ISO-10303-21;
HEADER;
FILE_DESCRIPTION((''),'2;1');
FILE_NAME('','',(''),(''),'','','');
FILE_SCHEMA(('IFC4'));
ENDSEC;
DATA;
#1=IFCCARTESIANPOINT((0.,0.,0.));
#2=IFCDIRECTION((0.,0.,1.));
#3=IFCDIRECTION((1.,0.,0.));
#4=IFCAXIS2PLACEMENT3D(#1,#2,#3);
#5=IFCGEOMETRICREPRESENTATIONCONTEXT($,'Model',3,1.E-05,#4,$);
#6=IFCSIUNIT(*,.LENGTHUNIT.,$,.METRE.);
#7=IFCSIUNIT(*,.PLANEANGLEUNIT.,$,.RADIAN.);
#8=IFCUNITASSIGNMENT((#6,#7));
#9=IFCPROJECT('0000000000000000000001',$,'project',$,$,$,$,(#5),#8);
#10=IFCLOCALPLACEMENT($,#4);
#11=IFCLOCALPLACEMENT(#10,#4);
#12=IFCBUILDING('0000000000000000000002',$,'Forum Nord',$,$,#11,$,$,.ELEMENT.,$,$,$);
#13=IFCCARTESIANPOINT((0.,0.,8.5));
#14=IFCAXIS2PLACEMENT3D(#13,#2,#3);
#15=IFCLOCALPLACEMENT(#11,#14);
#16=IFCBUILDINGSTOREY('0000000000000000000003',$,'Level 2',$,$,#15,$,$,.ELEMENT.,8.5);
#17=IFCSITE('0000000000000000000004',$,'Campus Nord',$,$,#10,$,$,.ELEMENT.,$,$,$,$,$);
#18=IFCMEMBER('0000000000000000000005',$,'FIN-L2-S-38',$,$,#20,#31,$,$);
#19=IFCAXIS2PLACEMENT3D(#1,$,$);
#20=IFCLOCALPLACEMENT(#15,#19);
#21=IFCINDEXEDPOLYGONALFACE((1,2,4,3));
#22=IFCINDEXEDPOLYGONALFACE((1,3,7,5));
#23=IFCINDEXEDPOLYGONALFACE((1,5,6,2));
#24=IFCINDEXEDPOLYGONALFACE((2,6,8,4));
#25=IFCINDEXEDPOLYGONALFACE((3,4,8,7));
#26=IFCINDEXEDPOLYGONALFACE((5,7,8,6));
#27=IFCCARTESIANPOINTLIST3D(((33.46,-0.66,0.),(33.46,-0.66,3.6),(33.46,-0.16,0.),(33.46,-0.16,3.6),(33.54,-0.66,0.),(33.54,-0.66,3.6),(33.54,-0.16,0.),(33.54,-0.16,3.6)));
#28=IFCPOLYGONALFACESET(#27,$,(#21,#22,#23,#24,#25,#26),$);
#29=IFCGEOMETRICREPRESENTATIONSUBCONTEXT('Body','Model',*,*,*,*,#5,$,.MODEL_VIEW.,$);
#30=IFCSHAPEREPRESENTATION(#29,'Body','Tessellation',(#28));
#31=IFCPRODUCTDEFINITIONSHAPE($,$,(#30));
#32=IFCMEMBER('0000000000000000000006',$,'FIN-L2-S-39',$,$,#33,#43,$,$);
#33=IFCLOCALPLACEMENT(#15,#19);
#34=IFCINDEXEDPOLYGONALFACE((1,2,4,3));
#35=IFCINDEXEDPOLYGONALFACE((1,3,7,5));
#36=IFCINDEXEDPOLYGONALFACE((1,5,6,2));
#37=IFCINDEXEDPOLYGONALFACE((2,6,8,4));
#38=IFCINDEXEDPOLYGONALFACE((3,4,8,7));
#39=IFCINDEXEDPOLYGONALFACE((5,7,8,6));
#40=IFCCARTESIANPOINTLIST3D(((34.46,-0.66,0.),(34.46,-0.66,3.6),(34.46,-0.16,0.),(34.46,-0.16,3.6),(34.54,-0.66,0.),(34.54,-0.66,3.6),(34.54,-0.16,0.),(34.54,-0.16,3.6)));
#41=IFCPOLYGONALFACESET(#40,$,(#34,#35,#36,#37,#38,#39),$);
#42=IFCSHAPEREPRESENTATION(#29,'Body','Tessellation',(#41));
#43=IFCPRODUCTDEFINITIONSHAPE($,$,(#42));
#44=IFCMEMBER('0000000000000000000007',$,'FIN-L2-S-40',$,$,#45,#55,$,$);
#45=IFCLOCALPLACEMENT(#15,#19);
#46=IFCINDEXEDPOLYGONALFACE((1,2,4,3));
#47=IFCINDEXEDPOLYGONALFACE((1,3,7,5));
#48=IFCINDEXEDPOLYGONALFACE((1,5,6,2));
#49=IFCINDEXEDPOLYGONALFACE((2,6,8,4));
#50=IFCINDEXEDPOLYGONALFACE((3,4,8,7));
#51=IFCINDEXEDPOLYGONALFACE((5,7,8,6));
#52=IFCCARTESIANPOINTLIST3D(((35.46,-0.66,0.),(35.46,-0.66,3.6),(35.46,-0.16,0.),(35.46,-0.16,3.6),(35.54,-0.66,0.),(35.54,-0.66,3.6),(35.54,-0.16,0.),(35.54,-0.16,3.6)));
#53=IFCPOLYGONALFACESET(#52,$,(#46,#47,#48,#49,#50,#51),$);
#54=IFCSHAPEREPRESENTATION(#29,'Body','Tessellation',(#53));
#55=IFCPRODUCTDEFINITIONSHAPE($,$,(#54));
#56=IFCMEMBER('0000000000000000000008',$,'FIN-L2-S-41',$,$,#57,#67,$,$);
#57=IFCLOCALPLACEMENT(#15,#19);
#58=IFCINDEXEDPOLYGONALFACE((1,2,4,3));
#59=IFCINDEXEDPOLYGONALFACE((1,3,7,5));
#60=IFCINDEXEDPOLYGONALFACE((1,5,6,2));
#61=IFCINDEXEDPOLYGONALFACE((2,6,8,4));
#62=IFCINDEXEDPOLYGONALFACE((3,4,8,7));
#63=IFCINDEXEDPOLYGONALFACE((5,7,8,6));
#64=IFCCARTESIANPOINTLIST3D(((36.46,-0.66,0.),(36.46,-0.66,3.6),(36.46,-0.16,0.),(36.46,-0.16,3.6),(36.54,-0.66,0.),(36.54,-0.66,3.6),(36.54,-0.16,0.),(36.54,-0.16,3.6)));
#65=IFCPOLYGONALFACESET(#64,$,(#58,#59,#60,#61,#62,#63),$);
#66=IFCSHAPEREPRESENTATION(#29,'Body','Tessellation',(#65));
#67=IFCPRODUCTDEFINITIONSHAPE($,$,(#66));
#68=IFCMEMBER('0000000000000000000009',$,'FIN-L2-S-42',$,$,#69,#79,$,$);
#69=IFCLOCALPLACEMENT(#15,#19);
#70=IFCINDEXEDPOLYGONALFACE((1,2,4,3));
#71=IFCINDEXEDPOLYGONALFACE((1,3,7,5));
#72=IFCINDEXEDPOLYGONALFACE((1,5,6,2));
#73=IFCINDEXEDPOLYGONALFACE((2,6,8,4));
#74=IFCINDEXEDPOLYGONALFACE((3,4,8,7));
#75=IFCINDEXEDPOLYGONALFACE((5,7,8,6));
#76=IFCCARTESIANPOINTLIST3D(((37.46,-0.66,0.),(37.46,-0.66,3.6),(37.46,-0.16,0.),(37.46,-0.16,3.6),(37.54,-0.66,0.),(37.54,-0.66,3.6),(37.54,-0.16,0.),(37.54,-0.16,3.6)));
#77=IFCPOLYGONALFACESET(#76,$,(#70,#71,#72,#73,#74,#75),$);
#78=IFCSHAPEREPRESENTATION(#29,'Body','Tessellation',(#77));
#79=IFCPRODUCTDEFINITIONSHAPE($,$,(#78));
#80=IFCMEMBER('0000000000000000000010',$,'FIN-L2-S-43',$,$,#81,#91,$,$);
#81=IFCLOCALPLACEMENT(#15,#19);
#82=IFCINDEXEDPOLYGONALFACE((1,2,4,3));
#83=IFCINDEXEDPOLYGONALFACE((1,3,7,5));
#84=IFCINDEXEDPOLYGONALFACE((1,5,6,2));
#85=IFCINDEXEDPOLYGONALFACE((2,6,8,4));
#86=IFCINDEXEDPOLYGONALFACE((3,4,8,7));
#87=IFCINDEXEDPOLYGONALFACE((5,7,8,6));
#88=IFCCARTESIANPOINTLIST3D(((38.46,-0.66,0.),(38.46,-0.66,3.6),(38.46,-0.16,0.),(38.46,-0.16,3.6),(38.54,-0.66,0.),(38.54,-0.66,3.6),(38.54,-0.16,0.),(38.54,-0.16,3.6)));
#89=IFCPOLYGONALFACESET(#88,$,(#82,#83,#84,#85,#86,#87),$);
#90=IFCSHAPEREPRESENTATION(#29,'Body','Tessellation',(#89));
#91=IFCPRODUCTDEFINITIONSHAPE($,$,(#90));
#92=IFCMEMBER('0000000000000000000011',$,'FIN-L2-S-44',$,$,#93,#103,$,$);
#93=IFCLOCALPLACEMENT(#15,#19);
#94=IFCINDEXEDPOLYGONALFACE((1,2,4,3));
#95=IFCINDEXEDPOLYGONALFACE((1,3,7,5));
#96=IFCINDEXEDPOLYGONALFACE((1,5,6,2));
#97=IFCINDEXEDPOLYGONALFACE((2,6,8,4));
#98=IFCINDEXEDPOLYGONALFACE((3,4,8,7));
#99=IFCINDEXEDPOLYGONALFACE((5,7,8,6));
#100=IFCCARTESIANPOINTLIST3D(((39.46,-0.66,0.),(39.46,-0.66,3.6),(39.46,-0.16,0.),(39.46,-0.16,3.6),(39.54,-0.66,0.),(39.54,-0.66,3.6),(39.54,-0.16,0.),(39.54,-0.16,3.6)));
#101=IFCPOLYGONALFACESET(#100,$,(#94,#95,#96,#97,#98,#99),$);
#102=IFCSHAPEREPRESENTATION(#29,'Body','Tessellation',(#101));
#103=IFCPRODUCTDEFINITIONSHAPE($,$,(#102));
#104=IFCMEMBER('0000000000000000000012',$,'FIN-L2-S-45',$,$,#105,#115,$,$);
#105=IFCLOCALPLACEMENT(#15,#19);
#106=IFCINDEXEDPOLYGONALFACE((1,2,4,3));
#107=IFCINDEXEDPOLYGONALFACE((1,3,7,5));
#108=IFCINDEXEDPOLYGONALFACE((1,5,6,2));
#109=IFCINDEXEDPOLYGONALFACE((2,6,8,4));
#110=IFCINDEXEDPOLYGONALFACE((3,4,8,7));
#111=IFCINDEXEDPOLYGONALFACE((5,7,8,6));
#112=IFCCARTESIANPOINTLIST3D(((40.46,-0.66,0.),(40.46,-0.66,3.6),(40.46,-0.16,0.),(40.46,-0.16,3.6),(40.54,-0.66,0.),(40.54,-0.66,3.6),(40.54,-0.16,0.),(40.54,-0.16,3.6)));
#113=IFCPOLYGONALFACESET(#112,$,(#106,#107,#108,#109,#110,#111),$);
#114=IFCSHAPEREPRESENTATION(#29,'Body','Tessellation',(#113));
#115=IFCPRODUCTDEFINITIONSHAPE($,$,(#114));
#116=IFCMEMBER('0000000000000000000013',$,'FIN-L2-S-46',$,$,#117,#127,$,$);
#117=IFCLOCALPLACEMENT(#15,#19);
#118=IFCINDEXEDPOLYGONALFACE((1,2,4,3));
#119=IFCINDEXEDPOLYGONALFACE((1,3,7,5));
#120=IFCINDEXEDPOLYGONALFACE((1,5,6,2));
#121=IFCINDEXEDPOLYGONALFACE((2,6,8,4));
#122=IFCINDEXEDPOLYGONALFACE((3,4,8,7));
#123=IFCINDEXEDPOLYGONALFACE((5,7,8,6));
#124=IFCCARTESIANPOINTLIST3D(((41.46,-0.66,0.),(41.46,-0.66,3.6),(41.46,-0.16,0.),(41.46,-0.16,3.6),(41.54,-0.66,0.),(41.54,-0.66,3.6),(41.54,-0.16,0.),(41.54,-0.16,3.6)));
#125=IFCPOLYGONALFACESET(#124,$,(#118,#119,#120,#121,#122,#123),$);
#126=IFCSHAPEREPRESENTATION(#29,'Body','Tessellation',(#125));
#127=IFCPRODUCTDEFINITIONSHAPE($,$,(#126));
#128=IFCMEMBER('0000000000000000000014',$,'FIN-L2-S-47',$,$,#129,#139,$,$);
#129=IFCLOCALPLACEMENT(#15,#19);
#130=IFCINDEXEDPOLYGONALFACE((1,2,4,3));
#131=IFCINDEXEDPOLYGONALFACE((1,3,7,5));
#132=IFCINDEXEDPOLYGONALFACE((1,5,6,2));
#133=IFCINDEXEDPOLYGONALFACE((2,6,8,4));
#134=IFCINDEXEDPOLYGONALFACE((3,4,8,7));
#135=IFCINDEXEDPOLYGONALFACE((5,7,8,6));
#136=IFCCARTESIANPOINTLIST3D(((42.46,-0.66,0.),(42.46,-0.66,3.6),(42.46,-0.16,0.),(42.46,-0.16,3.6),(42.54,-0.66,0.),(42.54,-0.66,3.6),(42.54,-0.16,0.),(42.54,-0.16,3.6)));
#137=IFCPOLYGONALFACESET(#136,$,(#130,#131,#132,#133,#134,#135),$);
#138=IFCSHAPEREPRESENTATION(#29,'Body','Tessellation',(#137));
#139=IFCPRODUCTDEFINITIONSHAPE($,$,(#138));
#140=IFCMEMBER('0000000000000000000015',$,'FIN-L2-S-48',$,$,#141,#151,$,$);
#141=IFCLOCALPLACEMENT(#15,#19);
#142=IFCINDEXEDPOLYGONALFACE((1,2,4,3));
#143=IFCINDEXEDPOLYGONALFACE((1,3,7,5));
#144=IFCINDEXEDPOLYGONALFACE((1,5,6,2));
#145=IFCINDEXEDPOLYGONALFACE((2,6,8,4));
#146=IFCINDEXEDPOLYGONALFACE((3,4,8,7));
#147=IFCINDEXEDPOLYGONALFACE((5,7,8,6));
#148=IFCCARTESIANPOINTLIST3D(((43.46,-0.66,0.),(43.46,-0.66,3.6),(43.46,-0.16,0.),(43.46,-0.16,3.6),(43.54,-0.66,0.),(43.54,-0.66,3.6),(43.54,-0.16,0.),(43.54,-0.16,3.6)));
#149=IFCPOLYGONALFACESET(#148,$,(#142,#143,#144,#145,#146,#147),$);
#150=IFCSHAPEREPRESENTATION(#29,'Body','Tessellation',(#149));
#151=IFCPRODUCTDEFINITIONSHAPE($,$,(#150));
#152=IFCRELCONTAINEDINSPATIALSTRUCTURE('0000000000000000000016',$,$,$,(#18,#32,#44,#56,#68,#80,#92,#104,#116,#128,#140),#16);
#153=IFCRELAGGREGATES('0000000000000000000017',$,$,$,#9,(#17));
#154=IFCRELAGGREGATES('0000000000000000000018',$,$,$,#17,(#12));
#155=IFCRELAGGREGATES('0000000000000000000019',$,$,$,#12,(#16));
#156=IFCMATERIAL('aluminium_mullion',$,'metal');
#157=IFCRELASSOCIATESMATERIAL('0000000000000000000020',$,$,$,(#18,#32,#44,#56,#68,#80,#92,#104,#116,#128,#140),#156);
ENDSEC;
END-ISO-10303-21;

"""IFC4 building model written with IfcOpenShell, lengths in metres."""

from ifc_helpers import new_model, si_unit, frame, origin_with_axes, place, context, subcontext, project, spatial, polyline, outline, extrude, material, element, save


model = new_model("IFC4")

# Units and contexts
model_context = context("Model", 3, precision=1e-05, world=origin_with_axes())
body_context = subcontext(model_context, "Body", "Model", "MODEL_VIEW")
ifc_project = project(units=[si_unit("LENGTHUNIT", "METRE"), si_unit("PLANEANGLEUNIT", "RADIAN")], contexts=[model_context])

# Site, building, storey
site_placement = place(None, origin_with_axes())
site = spatial("IfcSite", under=ifc_project, at=site_placement, Name="Campus Nord", CompositionType="ELEMENT")
building_placement = place(site_placement, origin_with_axes())
building = spatial("IfcBuilding", under=site, at=building_placement, Name="Forum Nord", CompositionType="ELEMENT")
storey_placement = place(building_placement, frame((0.0, 0.0, 8.5), z_axis=(0.0, 0.0, 1.0), x_axis=(1.0, 0.0, 0.0)))
storey = spatial("IfcBuildingStorey", under=building, at=storey_placement, Name="Level 2", CompositionType="ELEMENT", Elevation=8.5)

# Members
ifc_material_1 = material(Name="aluminium_mullion", Category="metal")
member_1_placement = place(storey_placement, origin_with_axes())
element("IfcMember", 1, at=member_1_placement, inside=storey, material=ifc_material_1, Name="FIN-L2-S-38", context=body_context, shape_type="SweptSolid", body=[
    extrude(outline(polyline([(33.46, -0.66), (33.54, -0.66), (33.54, -0.16), (33.46, -0.16), (33.46, -0.66)])), origin_with_axes(), (0.0, 0.0, 1.0), 3.6),
])
member_2_placement = place(storey_placement, origin_with_axes())
element("IfcMember", 2, at=member_2_placement, inside=storey, material=ifc_material_1, Name="FIN-L2-S-39", context=body_context, shape_type="SweptSolid", body=[
    extrude(outline(polyline([(34.46, -0.66), (34.54, -0.66), (34.54, -0.16), (34.46, -0.16), (34.46, -0.66)])), origin_with_axes(), (0.0, 0.0, 1.0), 3.6),
])
member_3_placement = place(storey_placement, origin_with_axes())
element("IfcMember", 3, at=member_3_placement, inside=storey, material=ifc_material_1, Name="FIN-L2-S-40", context=body_context, shape_type="SweptSolid", body=[
    extrude(outline(polyline([(35.46, -0.66), (35.54, -0.66), (35.54, -0.16), (35.46, -0.16), (35.46, -0.66)])), origin_with_axes(), (0.0, 0.0, 1.0), 3.6),
])
member_4_placement = place(storey_placement, origin_with_axes())
element("IfcMember", 4, at=member_4_placement, inside=storey, material=ifc_material_1, Name="FIN-L2-S-41", context=body_context, shape_type="SweptSolid", body=[
    extrude(outline(polyline([(36.46, -0.66), (36.54, -0.66), (36.54, -0.16), (36.46, -0.16), (36.46, -0.66)])), origin_with_axes(), (0.0, 0.0, 1.0), 3.6),
])
member_5_placement = place(storey_placement, origin_with_axes())
element("IfcMember", 5, at=member_5_placement, inside=storey, material=ifc_material_1, Name="FIN-L2-S-42", context=body_context, shape_type="SweptSolid", body=[
    extrude(outline(polyline([(37.46, -0.66), (37.54, -0.66), (37.54, -0.16), (37.46, -0.16), (37.46, -0.66)])), origin_with_axes(), (0.0, 0.0, 1.0), 3.6),
])
member_6_placement = place(storey_placement, origin_with_axes())
element("IfcMember", 6, at=member_6_placement, inside=storey, material=ifc_material_1, Name="FIN-L2-S-43", context=body_context, shape_type="SweptSolid", body=[
    extrude(outline(polyline([(38.46, -0.66), (38.54, -0.66), (38.54, -0.16), (38.46, -0.16), (38.46, -0.66)])), origin_with_axes(), (0.0, 0.0, 1.0), 3.6),
])
member_7_placement = place(storey_placement, origin_with_axes())
element("IfcMember", 7, at=member_7_placement, inside=storey, material=ifc_material_1, Name="FIN-L2-S-44", context=body_context, shape_type="SweptSolid", body=[
    extrude(outline(polyline([(39.46, -0.66), (39.54, -0.66), (39.54, -0.16), (39.46, -0.16), (39.46, -0.66)])), origin_with_axes(), (0.0, 0.0, 1.0), 3.6),
])
member_8_placement = place(storey_placement, origin_with_axes())
element("IfcMember", 8, at=member_8_placement, inside=storey, material=ifc_material_1, Name="FIN-L2-S-45", context=body_context, shape_type="SweptSolid", body=[
    extrude(outline(polyline([(40.46, -0.66), (40.54, -0.66), (40.54, -0.16), (40.46, -0.16), (40.46, -0.66)])), origin_with_axes(), (0.0, 0.0, 1.0), 3.6),
])
member_9_placement = place(storey_placement, origin_with_axes())
element("IfcMember", 9, at=member_9_placement, inside=storey, material=ifc_material_1, Name="FIN-L2-S-46", context=body_context, shape_type="SweptSolid", body=[
    extrude(outline(polyline([(41.46, -0.66), (41.54, -0.66), (41.54, -0.16), (41.46, -0.16), (41.46, -0.66)])), origin_with_axes(), (0.0, 0.0, 1.0), 3.6),
])
member_10_placement = place(storey_placement, origin_with_axes())
element("IfcMember", 10, at=member_10_placement, inside=storey, material=ifc_material_1, Name="FIN-L2-S-47", context=body_context, shape_type="SweptSolid", body=[
    extrude(outline(polyline([(42.46, -0.66), (42.54, -0.66), (42.54, -0.16), (42.46, -0.16), (42.46, -0.66)])), origin_with_axes(), (0.0, 0.0, 1.0), 3.6),
])
member_11_placement = place(storey_placement, origin_with_axes())
element("IfcMember", 11, at=member_11_placement, inside=storey, material=ifc_material_1, Name="FIN-L2-S-48", context=body_context, shape_type="SweptSolid", body=[
    extrude(outline(polyline([(43.46, -0.66), (43.54, -0.66), (43.54, -0.16), (43.46, -0.16), (43.46, -0.66)])), origin_with_axes(), (0.0, 0.0, 1.0), 3.6),
])

save(model, "model.ifc")
